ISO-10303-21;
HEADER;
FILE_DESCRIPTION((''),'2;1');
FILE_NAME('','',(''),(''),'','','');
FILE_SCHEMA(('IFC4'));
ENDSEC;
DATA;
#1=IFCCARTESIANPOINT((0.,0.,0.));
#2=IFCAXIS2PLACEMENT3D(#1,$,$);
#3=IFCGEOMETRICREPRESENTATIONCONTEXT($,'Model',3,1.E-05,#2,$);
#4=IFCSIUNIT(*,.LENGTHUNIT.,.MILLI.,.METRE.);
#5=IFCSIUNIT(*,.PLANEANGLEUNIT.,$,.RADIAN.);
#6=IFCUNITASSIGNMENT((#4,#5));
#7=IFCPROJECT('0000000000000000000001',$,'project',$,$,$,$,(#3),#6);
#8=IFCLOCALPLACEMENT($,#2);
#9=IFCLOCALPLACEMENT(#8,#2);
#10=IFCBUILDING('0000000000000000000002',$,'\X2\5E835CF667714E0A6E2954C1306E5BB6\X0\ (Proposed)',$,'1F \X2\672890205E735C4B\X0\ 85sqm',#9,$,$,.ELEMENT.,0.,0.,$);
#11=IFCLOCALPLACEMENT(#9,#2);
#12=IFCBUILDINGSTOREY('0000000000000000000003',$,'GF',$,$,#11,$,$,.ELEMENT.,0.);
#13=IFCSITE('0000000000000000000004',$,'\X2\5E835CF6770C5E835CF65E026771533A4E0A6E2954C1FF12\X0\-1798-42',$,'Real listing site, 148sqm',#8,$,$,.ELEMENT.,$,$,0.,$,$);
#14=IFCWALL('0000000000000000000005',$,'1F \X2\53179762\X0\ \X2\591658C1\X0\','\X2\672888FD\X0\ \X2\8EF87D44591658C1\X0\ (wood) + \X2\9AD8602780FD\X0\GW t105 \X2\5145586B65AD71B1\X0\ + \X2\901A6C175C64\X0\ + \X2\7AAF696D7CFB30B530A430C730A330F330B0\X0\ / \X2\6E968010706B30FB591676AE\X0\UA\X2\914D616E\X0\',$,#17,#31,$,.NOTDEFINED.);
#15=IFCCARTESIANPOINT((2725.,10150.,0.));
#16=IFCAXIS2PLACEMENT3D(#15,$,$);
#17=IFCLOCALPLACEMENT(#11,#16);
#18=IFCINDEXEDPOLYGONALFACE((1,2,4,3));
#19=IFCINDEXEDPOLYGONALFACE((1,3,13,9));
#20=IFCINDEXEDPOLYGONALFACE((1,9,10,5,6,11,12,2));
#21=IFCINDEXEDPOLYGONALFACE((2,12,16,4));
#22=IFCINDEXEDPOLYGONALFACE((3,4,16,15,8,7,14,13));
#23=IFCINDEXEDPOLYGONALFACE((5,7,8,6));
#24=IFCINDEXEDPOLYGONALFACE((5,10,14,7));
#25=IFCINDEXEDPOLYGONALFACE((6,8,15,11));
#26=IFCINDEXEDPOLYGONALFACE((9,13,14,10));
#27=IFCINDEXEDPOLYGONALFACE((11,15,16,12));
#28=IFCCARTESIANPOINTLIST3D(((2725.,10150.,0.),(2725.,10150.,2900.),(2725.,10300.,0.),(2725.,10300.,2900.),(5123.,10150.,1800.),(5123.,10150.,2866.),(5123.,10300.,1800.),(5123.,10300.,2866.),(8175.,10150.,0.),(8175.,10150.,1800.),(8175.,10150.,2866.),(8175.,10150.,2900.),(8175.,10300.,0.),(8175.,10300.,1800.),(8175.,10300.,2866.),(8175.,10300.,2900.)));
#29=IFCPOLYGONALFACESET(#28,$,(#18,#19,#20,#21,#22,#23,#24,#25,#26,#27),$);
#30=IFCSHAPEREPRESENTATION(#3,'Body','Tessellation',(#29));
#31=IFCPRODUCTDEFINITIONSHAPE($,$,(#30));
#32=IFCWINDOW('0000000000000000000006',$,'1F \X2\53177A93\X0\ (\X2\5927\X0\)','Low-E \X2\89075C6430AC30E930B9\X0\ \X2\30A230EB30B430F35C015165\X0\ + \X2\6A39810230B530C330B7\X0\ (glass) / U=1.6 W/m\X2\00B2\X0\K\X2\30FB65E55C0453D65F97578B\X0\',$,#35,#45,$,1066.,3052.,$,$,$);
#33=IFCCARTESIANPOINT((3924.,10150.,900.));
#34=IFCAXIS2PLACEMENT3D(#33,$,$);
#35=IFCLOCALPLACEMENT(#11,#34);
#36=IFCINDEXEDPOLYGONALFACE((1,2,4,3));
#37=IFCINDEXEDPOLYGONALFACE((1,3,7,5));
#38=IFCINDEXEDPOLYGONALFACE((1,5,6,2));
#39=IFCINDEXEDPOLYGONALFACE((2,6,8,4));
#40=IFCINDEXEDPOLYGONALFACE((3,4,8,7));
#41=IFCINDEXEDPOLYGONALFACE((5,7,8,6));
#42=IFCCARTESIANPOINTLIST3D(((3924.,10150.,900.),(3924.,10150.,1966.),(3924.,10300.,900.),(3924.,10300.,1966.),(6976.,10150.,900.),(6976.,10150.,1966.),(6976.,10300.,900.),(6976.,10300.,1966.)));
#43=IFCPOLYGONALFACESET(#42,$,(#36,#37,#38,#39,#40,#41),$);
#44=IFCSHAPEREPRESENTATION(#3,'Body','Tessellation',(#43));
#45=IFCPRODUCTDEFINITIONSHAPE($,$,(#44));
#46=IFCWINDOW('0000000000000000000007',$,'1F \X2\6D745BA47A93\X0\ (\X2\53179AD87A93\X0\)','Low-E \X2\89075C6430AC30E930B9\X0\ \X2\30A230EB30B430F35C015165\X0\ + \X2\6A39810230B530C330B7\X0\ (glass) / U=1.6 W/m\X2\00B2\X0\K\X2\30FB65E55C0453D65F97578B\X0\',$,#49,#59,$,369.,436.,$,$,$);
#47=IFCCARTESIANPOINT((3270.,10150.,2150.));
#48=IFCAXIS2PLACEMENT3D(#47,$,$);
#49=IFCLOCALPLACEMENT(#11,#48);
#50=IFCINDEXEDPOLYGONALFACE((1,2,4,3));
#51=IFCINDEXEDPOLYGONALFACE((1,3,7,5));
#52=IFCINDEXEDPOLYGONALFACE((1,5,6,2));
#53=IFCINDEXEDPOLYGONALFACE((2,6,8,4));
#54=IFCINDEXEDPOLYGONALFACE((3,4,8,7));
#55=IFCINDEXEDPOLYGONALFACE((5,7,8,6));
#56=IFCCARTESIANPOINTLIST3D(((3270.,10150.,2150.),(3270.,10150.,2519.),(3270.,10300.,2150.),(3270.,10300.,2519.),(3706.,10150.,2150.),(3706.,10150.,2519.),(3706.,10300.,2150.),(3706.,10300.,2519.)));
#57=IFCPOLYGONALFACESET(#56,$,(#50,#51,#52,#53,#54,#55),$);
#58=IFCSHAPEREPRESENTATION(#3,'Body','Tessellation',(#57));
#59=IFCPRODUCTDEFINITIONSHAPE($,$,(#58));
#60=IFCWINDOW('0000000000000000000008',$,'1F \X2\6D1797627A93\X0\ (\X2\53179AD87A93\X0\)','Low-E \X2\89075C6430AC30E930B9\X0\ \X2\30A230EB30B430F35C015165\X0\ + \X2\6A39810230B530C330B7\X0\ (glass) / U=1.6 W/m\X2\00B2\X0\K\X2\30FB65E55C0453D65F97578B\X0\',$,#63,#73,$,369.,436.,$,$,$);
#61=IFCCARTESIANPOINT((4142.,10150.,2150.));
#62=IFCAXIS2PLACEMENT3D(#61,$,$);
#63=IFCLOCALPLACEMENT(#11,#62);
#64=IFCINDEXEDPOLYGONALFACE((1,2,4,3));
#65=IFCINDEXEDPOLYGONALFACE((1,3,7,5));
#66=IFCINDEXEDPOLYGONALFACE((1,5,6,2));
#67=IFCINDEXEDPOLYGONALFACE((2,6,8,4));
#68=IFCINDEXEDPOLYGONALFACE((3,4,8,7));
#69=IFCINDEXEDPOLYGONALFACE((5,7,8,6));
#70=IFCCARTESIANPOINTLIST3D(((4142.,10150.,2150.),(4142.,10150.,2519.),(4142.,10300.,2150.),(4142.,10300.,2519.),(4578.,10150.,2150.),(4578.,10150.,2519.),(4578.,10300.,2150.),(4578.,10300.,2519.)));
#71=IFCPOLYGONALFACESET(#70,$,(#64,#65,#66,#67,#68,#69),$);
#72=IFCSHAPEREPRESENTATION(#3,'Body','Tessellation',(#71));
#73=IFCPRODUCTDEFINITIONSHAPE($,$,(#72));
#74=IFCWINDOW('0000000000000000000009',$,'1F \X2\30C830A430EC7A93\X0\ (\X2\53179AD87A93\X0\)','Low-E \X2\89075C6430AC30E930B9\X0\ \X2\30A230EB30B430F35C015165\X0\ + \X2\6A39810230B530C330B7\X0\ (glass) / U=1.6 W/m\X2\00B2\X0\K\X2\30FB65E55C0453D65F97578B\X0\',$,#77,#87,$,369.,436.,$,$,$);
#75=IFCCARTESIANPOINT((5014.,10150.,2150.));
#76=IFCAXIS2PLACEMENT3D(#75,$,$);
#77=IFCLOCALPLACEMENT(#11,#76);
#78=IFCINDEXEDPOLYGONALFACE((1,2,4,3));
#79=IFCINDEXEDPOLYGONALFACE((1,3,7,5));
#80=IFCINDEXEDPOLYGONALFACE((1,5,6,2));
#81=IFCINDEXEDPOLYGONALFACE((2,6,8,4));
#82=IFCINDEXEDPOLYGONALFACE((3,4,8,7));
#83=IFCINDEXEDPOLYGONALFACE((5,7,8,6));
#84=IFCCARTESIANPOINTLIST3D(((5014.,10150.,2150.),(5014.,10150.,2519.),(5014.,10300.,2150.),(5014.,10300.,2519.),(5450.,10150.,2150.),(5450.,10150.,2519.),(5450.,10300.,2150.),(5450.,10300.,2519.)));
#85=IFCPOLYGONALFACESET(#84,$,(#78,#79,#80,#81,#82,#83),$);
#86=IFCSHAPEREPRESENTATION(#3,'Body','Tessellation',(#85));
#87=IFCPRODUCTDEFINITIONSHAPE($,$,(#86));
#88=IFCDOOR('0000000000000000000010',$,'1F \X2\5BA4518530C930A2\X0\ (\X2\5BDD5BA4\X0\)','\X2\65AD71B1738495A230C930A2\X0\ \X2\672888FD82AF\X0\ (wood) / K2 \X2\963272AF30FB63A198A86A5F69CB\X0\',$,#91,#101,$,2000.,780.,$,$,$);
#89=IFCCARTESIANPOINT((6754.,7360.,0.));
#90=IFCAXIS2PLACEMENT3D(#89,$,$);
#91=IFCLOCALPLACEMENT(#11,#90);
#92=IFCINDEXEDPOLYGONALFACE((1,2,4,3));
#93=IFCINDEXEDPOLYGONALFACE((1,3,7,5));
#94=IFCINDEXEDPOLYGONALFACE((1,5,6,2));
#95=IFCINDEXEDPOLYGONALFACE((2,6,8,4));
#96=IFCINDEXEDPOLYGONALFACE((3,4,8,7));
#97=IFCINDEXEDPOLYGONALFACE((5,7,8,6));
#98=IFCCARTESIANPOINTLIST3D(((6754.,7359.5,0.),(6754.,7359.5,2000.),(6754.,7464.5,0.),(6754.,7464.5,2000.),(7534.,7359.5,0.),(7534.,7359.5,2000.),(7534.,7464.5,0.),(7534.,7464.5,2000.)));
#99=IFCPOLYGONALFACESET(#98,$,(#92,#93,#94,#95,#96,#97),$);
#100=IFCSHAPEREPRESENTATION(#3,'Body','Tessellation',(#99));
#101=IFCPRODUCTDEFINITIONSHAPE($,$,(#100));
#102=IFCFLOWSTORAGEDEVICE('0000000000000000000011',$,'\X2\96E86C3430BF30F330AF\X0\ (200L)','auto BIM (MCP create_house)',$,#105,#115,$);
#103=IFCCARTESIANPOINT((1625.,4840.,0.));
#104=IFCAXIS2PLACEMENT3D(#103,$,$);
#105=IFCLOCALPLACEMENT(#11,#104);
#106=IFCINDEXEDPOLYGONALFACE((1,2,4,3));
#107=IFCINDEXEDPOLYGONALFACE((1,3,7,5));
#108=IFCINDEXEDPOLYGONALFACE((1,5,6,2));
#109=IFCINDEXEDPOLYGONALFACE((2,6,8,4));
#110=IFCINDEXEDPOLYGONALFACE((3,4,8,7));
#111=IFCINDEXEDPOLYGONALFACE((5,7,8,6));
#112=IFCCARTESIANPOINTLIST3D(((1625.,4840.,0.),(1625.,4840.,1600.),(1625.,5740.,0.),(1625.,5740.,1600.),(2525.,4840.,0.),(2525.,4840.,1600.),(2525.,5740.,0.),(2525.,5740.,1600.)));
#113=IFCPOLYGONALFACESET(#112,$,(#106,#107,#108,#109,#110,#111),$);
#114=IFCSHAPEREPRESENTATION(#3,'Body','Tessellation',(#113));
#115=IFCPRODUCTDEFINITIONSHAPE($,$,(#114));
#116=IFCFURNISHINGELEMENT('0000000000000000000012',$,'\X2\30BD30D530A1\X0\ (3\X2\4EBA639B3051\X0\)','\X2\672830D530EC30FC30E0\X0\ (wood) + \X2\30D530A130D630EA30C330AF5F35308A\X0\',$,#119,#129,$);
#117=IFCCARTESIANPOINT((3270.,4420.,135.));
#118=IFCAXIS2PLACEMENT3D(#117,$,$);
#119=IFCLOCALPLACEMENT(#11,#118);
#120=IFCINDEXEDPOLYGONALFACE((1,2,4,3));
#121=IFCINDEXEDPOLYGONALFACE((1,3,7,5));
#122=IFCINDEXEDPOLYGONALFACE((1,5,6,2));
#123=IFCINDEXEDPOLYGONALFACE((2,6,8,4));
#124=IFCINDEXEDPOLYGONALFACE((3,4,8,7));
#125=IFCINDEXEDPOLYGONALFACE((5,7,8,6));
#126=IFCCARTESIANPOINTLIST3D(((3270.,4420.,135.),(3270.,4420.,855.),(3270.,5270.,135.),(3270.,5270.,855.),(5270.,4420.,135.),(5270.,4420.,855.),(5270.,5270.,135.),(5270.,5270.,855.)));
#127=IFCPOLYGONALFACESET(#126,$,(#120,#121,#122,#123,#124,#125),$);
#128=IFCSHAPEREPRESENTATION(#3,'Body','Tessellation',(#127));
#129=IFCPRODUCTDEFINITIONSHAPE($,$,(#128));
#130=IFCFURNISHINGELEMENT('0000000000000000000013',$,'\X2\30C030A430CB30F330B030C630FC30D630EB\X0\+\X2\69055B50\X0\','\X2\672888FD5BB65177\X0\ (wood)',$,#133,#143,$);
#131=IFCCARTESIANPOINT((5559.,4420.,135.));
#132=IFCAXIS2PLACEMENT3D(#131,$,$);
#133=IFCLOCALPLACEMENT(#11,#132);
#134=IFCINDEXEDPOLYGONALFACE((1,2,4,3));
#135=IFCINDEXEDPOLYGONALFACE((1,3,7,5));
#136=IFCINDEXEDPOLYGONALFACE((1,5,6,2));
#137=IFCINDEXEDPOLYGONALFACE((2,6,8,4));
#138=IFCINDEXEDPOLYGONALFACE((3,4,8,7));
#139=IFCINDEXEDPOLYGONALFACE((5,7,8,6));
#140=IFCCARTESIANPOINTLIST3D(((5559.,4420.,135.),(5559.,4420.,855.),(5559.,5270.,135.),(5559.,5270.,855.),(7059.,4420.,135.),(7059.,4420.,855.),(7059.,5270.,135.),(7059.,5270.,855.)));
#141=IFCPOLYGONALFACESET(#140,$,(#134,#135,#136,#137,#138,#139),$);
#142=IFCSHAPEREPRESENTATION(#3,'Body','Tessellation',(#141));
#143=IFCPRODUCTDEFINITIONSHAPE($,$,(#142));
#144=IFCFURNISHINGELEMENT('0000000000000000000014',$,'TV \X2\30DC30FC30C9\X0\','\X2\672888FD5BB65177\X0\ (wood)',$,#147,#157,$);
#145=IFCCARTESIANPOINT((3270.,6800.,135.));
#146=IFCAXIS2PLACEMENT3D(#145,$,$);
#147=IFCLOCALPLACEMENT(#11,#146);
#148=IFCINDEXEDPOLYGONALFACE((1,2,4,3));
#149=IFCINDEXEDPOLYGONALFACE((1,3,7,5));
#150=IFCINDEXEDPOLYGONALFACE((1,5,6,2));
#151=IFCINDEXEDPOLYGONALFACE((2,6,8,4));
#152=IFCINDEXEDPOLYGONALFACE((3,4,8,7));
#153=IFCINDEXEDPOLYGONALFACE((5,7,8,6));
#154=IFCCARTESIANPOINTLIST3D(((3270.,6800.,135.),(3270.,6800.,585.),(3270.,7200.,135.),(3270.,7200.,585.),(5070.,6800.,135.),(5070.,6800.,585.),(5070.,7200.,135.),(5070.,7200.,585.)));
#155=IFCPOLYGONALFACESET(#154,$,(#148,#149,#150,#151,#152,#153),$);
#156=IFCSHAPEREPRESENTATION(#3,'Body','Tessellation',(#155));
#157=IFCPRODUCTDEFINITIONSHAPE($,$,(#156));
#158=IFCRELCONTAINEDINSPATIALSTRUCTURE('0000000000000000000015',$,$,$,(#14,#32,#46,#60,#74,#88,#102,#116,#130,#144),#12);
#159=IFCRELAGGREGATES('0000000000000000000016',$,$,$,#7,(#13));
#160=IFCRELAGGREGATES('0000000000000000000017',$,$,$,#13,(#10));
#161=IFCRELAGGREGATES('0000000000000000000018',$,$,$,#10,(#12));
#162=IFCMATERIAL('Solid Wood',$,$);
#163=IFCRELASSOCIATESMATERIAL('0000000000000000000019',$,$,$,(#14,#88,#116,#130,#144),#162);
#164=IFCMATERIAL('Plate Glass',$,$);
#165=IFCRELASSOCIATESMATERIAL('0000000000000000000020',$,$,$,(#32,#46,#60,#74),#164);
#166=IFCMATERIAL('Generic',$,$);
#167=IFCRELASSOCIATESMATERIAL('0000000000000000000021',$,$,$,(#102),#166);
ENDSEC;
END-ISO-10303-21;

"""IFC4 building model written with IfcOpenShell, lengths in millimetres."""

from ifc_helpers import new_model, si_unit, frame, frame_2d, origin, place, context, project, spatial, rectangle, extrude, material, element, fill, save


model = new_model("IFC4")

# Units and contexts
model_context = context("Model", 3, precision=1e-05, world=origin())
ifc_project = project(units=[si_unit("LENGTHUNIT", "METRE", prefix="MILLI"), si_unit("PLANEANGLEUNIT", "RADIAN")], contexts=[model_context])

# Site, building, storey
site_placement = place(None, origin())
site = spatial("IfcSite", under=ifc_project, at=site_placement, Name="広島県広島市東区上温品２-1798-42", ObjectType="Real listing site, 148sqm", CompositionType="ELEMENT", RefElevation=0.0)
building_placement = place(site_placement, origin())
building = spatial("IfcBuilding", under=site, at=building_placement, Name="広島東上温品の家 (Proposed)", ObjectType="1F 木造平屋 85sqm", CompositionType="ELEMENT", ElevationOfRefHeight=0.0, ElevationOfTerrain=0.0)
storey_placement = place(building_placement, origin())
storey = spatial("IfcBuildingStorey", under=building, at=storey_placement, Name="GF", CompositionType="ELEMENT", Elevation=0.0)

# Wall, openings, windows
ifc_material_1 = material(Name="Solid Wood")
wall_1_placement = place(storey_placement, frame((2725.0, 10150.0, 0.0)))
wall_1 = element("IfcWall", 1, at=wall_1_placement, inside=storey, material=ifc_material_1, Name="1F 北面 外壁", Description="木製 軸組外壁 (wood) + 高性能GW t105 充填断熱 + 通気層 + 窯業系サイディング / 準耐火・外皮UA配慮", PredefinedType="NOTDEFINED", context=model_context, shape_type="SweptSolid", body=[
    extrude(rectangle(XDim=5450.0, YDim=150.0, at=frame_2d((2725.0, 75.0))), frame((2725.0, 10150.0, 0.0)), (0.0, 0.0, 1.0), 2900.0),
])
opening_1_placement = place(storey_placement, frame((3924.0, 10150.0, 900.0)))
opening_1 = element("IfcOpeningElement", 2, at=opening_1_placement, cuts=wall_1, PredefinedType="NOTDEFINED", context=model_context, shape_type="SweptSolid", body=[
    extrude(rectangle(XDim=3052.0, YDim=150.0, at=frame_2d((1526.0, 75.0))), frame((3924.0, 10150.0, 900.0)), (0.0, 0.0, 1.0), 1066.0),
])
opening_2_placement = place(storey_placement, frame((3270.0, 10150.0, 2150.0)))
opening_2 = element("IfcOpeningElement", 3, at=opening_2_placement, cuts=wall_1, PredefinedType="NOTDEFINED", context=model_context, shape_type="SweptSolid", body=[
    extrude(rectangle(XDim=436.0, YDim=150.0, at=frame_2d((218.0, 75.0))), frame((3270.0, 10150.0, 2150.0)), (0.0, 0.0, 1.0), 369.0),
])
opening_3_placement = place(storey_placement, frame((4142.0, 10150.0, 2150.0)))
opening_3 = element("IfcOpeningElement", 4, at=opening_3_placement, cuts=wall_1, PredefinedType="NOTDEFINED", context=model_context, shape_type="SweptSolid", body=[
    extrude(rectangle(XDim=436.0, YDim=150.0, at=frame_2d((218.0, 75.0))), frame((4142.0, 10150.0, 2150.0)), (0.0, 0.0, 1.0), 369.0),
])
opening_4_placement = place(storey_placement, frame((5014.0, 10150.0, 2150.0)))
opening_4 = element("IfcOpeningElement", 5, at=opening_4_placement, cuts=wall_1, PredefinedType="NOTDEFINED", context=model_context, shape_type="SweptSolid", body=[
    extrude(rectangle(XDim=436.0, YDim=150.0, at=frame_2d((218.0, 75.0))), frame((5014.0, 10150.0, 2150.0)), (0.0, 0.0, 1.0), 369.0),
])
ifc_material_2 = material(Name="Plate Glass")
window_1_placement = place(storey_placement, frame((3924.0, 10150.0, 900.0)))
window_1 = element("IfcWindow", 6, at=window_1_placement, inside=storey, material=ifc_material_2, Name="1F 北窓 (大)", Description="Low-E 複層ガラス アルゴン封入 + 樹脂サッシ (glass) / U=1.6 W/m²K・日射取得型", OverallHeight=1066.0, OverallWidth=3052.0, context=model_context, shape_type="SweptSolid", body=[
    extrude(rectangle(XDim=3052.0, YDim=150.0, at=frame_2d((1526.0, 75.0))), frame((3924.0, 10150.0, 900.0)), (0.0, 0.0, 1.0), 1066.0),
])
fill(opening_1, window_1)
window_2_placement = place(storey_placement, frame((3270.0, 10150.0, 2150.0)))
window_2 = element("IfcWindow", 7, at=window_2_placement, inside=storey, material=ifc_material_2, Name="1F 浴室窓 (北高窓)", Description="Low-E 複層ガラス アルゴン封入 + 樹脂サッシ (glass) / U=1.6 W/m²K・日射取得型", OverallHeight=369.0, OverallWidth=436.0, context=model_context, shape_type="SweptSolid", body=[
    extrude(rectangle(XDim=436.0, YDim=150.0, at=frame_2d((218.0, 75.0))), frame((3270.0, 10150.0, 2150.0)), (0.0, 0.0, 1.0), 369.0),
])
fill(opening_2, window_2)
window_3_placement = place(storey_placement, frame((4142.0, 10150.0, 2150.0)))
window_3 = element("IfcWindow", 8, at=window_3_placement, inside=storey, material=ifc_material_2, Name="1F 洗面窓 (北高窓)", Description="Low-E 複層ガラス アルゴン封入 + 樹脂サッシ (glass) / U=1.6 W/m²K・日射取得型", OverallHeight=369.0, OverallWidth=436.0, context=model_context, shape_type="SweptSolid", body=[
    extrude(rectangle(XDim=436.0, YDim=150.0, at=frame_2d((218.0, 75.0))), frame((4142.0, 10150.0, 2150.0)), (0.0, 0.0, 1.0), 369.0),
])
fill(opening_3, window_3)
window_4_placement = place(storey_placement, frame((5014.0, 10150.0, 2150.0)))
window_4 = element("IfcWindow", 9, at=window_4_placement, inside=storey, material=ifc_material_2, Name="1F トイレ窓 (北高窓)", Description="Low-E 複層ガラス アルゴン封入 + 樹脂サッシ (glass) / U=1.6 W/m²K・日射取得型", OverallHeight=369.0, OverallWidth=436.0, context=model_context, shape_type="SweptSolid", body=[
    extrude(rectangle(XDim=436.0, YDim=150.0, at=frame_2d((218.0, 75.0))), frame((5014.0, 10150.0, 2150.0)), (0.0, 0.0, 1.0), 369.0),
])
fill(opening_4, window_4)

# Door
door_1_placement = place(storey_placement, frame((6754.0, 7360.0, 0.0)))
element("IfcDoor", 10, at=door_1_placement, inside=storey, material=ifc_material_1, Name="1F 室内ドア (寝室)", Description="断熱玄関ドア 木製芯 (wood) / K2 防犯・採風機構", OverallHeight=2000.0, OverallWidth=780.0, context=model_context, shape_type="SweptSolid", body=[
    extrude(rectangle(XDim=780.0, YDim=105.0, at=frame_2d((390.0, 52.0))), frame((6754.0, 7360.0, 0.0)), (0.0, 0.0, 1.0), 2000.0),
])

# Flow storage device
ifc_material_3 = material(Name="Generic")
flow_storage_device_placement = place(storey_placement, frame((1625.0, 4840.0, 0.0)))
element("IfcFlowStorageDevice", 11, at=flow_storage_device_placement, inside=storey, material=ifc_material_3, Name="雨水タンク (200L)", Description="auto BIM (MCP create_house)", context=model_context, shape_type="SweptSolid", body=[
    extrude(rectangle(XDim=900.0, YDim=900.0, at=frame_2d((450.0, 450.0))), frame((1625.0, 4840.0, 0.0)), (0.0, 0.0, 1.0), 1600.0),
])

# Furnishing elements
furnishing_1_placement = place(storey_placement, frame((3270.0, 4420.0, 135.0)))
element("IfcFurnishingElement", 12, at=furnishing_1_placement, inside=storey, material=ifc_material_1, Name="ソファ (3人掛け)", Description="木フレーム (wood) + ファブリック張り", context=model_context, shape_type="SweptSolid", body=[
    extrude(rectangle(XDim=2000.0, YDim=850.0, at=frame_2d((1000.0, 425.0))), frame((3270.0, 4420.0, 135.0)), (0.0, 0.0, 1.0), 720.0),
])
furnishing_2_placement = place(storey_placement, frame((5559.0, 4420.0, 135.0)))
element("IfcFurnishingElement", 13, at=furnishing_2_placement, inside=storey, material=ifc_material_1, Name="ダイニングテーブル+椅子", Description="木製家具 (wood)", context=model_context, shape_type="SweptSolid", body=[
    extrude(rectangle(XDim=1500.0, YDim=850.0, at=frame_2d((750.0, 425.0))), frame((5559.0, 4420.0, 135.0)), (0.0, 0.0, 1.0), 720.0),
])
furnishing_3_placement = place(storey_placement, frame((3270.0, 6800.0, 135.0)))
element("IfcFurnishingElement", 14, at=furnishing_3_placement, inside=storey, material=ifc_material_1, Name="TV ボード", Description="木製家具 (wood)", context=model_context, shape_type="SweptSolid", body=[
    extrude(rectangle(XDim=1800.0, YDim=400.0, at=frame_2d((900.0, 200.0))), frame((3270.0, 6800.0, 135.0)), (0.0, 0.0, 1.0), 450.0),
])

save(model, "model.ifc")
